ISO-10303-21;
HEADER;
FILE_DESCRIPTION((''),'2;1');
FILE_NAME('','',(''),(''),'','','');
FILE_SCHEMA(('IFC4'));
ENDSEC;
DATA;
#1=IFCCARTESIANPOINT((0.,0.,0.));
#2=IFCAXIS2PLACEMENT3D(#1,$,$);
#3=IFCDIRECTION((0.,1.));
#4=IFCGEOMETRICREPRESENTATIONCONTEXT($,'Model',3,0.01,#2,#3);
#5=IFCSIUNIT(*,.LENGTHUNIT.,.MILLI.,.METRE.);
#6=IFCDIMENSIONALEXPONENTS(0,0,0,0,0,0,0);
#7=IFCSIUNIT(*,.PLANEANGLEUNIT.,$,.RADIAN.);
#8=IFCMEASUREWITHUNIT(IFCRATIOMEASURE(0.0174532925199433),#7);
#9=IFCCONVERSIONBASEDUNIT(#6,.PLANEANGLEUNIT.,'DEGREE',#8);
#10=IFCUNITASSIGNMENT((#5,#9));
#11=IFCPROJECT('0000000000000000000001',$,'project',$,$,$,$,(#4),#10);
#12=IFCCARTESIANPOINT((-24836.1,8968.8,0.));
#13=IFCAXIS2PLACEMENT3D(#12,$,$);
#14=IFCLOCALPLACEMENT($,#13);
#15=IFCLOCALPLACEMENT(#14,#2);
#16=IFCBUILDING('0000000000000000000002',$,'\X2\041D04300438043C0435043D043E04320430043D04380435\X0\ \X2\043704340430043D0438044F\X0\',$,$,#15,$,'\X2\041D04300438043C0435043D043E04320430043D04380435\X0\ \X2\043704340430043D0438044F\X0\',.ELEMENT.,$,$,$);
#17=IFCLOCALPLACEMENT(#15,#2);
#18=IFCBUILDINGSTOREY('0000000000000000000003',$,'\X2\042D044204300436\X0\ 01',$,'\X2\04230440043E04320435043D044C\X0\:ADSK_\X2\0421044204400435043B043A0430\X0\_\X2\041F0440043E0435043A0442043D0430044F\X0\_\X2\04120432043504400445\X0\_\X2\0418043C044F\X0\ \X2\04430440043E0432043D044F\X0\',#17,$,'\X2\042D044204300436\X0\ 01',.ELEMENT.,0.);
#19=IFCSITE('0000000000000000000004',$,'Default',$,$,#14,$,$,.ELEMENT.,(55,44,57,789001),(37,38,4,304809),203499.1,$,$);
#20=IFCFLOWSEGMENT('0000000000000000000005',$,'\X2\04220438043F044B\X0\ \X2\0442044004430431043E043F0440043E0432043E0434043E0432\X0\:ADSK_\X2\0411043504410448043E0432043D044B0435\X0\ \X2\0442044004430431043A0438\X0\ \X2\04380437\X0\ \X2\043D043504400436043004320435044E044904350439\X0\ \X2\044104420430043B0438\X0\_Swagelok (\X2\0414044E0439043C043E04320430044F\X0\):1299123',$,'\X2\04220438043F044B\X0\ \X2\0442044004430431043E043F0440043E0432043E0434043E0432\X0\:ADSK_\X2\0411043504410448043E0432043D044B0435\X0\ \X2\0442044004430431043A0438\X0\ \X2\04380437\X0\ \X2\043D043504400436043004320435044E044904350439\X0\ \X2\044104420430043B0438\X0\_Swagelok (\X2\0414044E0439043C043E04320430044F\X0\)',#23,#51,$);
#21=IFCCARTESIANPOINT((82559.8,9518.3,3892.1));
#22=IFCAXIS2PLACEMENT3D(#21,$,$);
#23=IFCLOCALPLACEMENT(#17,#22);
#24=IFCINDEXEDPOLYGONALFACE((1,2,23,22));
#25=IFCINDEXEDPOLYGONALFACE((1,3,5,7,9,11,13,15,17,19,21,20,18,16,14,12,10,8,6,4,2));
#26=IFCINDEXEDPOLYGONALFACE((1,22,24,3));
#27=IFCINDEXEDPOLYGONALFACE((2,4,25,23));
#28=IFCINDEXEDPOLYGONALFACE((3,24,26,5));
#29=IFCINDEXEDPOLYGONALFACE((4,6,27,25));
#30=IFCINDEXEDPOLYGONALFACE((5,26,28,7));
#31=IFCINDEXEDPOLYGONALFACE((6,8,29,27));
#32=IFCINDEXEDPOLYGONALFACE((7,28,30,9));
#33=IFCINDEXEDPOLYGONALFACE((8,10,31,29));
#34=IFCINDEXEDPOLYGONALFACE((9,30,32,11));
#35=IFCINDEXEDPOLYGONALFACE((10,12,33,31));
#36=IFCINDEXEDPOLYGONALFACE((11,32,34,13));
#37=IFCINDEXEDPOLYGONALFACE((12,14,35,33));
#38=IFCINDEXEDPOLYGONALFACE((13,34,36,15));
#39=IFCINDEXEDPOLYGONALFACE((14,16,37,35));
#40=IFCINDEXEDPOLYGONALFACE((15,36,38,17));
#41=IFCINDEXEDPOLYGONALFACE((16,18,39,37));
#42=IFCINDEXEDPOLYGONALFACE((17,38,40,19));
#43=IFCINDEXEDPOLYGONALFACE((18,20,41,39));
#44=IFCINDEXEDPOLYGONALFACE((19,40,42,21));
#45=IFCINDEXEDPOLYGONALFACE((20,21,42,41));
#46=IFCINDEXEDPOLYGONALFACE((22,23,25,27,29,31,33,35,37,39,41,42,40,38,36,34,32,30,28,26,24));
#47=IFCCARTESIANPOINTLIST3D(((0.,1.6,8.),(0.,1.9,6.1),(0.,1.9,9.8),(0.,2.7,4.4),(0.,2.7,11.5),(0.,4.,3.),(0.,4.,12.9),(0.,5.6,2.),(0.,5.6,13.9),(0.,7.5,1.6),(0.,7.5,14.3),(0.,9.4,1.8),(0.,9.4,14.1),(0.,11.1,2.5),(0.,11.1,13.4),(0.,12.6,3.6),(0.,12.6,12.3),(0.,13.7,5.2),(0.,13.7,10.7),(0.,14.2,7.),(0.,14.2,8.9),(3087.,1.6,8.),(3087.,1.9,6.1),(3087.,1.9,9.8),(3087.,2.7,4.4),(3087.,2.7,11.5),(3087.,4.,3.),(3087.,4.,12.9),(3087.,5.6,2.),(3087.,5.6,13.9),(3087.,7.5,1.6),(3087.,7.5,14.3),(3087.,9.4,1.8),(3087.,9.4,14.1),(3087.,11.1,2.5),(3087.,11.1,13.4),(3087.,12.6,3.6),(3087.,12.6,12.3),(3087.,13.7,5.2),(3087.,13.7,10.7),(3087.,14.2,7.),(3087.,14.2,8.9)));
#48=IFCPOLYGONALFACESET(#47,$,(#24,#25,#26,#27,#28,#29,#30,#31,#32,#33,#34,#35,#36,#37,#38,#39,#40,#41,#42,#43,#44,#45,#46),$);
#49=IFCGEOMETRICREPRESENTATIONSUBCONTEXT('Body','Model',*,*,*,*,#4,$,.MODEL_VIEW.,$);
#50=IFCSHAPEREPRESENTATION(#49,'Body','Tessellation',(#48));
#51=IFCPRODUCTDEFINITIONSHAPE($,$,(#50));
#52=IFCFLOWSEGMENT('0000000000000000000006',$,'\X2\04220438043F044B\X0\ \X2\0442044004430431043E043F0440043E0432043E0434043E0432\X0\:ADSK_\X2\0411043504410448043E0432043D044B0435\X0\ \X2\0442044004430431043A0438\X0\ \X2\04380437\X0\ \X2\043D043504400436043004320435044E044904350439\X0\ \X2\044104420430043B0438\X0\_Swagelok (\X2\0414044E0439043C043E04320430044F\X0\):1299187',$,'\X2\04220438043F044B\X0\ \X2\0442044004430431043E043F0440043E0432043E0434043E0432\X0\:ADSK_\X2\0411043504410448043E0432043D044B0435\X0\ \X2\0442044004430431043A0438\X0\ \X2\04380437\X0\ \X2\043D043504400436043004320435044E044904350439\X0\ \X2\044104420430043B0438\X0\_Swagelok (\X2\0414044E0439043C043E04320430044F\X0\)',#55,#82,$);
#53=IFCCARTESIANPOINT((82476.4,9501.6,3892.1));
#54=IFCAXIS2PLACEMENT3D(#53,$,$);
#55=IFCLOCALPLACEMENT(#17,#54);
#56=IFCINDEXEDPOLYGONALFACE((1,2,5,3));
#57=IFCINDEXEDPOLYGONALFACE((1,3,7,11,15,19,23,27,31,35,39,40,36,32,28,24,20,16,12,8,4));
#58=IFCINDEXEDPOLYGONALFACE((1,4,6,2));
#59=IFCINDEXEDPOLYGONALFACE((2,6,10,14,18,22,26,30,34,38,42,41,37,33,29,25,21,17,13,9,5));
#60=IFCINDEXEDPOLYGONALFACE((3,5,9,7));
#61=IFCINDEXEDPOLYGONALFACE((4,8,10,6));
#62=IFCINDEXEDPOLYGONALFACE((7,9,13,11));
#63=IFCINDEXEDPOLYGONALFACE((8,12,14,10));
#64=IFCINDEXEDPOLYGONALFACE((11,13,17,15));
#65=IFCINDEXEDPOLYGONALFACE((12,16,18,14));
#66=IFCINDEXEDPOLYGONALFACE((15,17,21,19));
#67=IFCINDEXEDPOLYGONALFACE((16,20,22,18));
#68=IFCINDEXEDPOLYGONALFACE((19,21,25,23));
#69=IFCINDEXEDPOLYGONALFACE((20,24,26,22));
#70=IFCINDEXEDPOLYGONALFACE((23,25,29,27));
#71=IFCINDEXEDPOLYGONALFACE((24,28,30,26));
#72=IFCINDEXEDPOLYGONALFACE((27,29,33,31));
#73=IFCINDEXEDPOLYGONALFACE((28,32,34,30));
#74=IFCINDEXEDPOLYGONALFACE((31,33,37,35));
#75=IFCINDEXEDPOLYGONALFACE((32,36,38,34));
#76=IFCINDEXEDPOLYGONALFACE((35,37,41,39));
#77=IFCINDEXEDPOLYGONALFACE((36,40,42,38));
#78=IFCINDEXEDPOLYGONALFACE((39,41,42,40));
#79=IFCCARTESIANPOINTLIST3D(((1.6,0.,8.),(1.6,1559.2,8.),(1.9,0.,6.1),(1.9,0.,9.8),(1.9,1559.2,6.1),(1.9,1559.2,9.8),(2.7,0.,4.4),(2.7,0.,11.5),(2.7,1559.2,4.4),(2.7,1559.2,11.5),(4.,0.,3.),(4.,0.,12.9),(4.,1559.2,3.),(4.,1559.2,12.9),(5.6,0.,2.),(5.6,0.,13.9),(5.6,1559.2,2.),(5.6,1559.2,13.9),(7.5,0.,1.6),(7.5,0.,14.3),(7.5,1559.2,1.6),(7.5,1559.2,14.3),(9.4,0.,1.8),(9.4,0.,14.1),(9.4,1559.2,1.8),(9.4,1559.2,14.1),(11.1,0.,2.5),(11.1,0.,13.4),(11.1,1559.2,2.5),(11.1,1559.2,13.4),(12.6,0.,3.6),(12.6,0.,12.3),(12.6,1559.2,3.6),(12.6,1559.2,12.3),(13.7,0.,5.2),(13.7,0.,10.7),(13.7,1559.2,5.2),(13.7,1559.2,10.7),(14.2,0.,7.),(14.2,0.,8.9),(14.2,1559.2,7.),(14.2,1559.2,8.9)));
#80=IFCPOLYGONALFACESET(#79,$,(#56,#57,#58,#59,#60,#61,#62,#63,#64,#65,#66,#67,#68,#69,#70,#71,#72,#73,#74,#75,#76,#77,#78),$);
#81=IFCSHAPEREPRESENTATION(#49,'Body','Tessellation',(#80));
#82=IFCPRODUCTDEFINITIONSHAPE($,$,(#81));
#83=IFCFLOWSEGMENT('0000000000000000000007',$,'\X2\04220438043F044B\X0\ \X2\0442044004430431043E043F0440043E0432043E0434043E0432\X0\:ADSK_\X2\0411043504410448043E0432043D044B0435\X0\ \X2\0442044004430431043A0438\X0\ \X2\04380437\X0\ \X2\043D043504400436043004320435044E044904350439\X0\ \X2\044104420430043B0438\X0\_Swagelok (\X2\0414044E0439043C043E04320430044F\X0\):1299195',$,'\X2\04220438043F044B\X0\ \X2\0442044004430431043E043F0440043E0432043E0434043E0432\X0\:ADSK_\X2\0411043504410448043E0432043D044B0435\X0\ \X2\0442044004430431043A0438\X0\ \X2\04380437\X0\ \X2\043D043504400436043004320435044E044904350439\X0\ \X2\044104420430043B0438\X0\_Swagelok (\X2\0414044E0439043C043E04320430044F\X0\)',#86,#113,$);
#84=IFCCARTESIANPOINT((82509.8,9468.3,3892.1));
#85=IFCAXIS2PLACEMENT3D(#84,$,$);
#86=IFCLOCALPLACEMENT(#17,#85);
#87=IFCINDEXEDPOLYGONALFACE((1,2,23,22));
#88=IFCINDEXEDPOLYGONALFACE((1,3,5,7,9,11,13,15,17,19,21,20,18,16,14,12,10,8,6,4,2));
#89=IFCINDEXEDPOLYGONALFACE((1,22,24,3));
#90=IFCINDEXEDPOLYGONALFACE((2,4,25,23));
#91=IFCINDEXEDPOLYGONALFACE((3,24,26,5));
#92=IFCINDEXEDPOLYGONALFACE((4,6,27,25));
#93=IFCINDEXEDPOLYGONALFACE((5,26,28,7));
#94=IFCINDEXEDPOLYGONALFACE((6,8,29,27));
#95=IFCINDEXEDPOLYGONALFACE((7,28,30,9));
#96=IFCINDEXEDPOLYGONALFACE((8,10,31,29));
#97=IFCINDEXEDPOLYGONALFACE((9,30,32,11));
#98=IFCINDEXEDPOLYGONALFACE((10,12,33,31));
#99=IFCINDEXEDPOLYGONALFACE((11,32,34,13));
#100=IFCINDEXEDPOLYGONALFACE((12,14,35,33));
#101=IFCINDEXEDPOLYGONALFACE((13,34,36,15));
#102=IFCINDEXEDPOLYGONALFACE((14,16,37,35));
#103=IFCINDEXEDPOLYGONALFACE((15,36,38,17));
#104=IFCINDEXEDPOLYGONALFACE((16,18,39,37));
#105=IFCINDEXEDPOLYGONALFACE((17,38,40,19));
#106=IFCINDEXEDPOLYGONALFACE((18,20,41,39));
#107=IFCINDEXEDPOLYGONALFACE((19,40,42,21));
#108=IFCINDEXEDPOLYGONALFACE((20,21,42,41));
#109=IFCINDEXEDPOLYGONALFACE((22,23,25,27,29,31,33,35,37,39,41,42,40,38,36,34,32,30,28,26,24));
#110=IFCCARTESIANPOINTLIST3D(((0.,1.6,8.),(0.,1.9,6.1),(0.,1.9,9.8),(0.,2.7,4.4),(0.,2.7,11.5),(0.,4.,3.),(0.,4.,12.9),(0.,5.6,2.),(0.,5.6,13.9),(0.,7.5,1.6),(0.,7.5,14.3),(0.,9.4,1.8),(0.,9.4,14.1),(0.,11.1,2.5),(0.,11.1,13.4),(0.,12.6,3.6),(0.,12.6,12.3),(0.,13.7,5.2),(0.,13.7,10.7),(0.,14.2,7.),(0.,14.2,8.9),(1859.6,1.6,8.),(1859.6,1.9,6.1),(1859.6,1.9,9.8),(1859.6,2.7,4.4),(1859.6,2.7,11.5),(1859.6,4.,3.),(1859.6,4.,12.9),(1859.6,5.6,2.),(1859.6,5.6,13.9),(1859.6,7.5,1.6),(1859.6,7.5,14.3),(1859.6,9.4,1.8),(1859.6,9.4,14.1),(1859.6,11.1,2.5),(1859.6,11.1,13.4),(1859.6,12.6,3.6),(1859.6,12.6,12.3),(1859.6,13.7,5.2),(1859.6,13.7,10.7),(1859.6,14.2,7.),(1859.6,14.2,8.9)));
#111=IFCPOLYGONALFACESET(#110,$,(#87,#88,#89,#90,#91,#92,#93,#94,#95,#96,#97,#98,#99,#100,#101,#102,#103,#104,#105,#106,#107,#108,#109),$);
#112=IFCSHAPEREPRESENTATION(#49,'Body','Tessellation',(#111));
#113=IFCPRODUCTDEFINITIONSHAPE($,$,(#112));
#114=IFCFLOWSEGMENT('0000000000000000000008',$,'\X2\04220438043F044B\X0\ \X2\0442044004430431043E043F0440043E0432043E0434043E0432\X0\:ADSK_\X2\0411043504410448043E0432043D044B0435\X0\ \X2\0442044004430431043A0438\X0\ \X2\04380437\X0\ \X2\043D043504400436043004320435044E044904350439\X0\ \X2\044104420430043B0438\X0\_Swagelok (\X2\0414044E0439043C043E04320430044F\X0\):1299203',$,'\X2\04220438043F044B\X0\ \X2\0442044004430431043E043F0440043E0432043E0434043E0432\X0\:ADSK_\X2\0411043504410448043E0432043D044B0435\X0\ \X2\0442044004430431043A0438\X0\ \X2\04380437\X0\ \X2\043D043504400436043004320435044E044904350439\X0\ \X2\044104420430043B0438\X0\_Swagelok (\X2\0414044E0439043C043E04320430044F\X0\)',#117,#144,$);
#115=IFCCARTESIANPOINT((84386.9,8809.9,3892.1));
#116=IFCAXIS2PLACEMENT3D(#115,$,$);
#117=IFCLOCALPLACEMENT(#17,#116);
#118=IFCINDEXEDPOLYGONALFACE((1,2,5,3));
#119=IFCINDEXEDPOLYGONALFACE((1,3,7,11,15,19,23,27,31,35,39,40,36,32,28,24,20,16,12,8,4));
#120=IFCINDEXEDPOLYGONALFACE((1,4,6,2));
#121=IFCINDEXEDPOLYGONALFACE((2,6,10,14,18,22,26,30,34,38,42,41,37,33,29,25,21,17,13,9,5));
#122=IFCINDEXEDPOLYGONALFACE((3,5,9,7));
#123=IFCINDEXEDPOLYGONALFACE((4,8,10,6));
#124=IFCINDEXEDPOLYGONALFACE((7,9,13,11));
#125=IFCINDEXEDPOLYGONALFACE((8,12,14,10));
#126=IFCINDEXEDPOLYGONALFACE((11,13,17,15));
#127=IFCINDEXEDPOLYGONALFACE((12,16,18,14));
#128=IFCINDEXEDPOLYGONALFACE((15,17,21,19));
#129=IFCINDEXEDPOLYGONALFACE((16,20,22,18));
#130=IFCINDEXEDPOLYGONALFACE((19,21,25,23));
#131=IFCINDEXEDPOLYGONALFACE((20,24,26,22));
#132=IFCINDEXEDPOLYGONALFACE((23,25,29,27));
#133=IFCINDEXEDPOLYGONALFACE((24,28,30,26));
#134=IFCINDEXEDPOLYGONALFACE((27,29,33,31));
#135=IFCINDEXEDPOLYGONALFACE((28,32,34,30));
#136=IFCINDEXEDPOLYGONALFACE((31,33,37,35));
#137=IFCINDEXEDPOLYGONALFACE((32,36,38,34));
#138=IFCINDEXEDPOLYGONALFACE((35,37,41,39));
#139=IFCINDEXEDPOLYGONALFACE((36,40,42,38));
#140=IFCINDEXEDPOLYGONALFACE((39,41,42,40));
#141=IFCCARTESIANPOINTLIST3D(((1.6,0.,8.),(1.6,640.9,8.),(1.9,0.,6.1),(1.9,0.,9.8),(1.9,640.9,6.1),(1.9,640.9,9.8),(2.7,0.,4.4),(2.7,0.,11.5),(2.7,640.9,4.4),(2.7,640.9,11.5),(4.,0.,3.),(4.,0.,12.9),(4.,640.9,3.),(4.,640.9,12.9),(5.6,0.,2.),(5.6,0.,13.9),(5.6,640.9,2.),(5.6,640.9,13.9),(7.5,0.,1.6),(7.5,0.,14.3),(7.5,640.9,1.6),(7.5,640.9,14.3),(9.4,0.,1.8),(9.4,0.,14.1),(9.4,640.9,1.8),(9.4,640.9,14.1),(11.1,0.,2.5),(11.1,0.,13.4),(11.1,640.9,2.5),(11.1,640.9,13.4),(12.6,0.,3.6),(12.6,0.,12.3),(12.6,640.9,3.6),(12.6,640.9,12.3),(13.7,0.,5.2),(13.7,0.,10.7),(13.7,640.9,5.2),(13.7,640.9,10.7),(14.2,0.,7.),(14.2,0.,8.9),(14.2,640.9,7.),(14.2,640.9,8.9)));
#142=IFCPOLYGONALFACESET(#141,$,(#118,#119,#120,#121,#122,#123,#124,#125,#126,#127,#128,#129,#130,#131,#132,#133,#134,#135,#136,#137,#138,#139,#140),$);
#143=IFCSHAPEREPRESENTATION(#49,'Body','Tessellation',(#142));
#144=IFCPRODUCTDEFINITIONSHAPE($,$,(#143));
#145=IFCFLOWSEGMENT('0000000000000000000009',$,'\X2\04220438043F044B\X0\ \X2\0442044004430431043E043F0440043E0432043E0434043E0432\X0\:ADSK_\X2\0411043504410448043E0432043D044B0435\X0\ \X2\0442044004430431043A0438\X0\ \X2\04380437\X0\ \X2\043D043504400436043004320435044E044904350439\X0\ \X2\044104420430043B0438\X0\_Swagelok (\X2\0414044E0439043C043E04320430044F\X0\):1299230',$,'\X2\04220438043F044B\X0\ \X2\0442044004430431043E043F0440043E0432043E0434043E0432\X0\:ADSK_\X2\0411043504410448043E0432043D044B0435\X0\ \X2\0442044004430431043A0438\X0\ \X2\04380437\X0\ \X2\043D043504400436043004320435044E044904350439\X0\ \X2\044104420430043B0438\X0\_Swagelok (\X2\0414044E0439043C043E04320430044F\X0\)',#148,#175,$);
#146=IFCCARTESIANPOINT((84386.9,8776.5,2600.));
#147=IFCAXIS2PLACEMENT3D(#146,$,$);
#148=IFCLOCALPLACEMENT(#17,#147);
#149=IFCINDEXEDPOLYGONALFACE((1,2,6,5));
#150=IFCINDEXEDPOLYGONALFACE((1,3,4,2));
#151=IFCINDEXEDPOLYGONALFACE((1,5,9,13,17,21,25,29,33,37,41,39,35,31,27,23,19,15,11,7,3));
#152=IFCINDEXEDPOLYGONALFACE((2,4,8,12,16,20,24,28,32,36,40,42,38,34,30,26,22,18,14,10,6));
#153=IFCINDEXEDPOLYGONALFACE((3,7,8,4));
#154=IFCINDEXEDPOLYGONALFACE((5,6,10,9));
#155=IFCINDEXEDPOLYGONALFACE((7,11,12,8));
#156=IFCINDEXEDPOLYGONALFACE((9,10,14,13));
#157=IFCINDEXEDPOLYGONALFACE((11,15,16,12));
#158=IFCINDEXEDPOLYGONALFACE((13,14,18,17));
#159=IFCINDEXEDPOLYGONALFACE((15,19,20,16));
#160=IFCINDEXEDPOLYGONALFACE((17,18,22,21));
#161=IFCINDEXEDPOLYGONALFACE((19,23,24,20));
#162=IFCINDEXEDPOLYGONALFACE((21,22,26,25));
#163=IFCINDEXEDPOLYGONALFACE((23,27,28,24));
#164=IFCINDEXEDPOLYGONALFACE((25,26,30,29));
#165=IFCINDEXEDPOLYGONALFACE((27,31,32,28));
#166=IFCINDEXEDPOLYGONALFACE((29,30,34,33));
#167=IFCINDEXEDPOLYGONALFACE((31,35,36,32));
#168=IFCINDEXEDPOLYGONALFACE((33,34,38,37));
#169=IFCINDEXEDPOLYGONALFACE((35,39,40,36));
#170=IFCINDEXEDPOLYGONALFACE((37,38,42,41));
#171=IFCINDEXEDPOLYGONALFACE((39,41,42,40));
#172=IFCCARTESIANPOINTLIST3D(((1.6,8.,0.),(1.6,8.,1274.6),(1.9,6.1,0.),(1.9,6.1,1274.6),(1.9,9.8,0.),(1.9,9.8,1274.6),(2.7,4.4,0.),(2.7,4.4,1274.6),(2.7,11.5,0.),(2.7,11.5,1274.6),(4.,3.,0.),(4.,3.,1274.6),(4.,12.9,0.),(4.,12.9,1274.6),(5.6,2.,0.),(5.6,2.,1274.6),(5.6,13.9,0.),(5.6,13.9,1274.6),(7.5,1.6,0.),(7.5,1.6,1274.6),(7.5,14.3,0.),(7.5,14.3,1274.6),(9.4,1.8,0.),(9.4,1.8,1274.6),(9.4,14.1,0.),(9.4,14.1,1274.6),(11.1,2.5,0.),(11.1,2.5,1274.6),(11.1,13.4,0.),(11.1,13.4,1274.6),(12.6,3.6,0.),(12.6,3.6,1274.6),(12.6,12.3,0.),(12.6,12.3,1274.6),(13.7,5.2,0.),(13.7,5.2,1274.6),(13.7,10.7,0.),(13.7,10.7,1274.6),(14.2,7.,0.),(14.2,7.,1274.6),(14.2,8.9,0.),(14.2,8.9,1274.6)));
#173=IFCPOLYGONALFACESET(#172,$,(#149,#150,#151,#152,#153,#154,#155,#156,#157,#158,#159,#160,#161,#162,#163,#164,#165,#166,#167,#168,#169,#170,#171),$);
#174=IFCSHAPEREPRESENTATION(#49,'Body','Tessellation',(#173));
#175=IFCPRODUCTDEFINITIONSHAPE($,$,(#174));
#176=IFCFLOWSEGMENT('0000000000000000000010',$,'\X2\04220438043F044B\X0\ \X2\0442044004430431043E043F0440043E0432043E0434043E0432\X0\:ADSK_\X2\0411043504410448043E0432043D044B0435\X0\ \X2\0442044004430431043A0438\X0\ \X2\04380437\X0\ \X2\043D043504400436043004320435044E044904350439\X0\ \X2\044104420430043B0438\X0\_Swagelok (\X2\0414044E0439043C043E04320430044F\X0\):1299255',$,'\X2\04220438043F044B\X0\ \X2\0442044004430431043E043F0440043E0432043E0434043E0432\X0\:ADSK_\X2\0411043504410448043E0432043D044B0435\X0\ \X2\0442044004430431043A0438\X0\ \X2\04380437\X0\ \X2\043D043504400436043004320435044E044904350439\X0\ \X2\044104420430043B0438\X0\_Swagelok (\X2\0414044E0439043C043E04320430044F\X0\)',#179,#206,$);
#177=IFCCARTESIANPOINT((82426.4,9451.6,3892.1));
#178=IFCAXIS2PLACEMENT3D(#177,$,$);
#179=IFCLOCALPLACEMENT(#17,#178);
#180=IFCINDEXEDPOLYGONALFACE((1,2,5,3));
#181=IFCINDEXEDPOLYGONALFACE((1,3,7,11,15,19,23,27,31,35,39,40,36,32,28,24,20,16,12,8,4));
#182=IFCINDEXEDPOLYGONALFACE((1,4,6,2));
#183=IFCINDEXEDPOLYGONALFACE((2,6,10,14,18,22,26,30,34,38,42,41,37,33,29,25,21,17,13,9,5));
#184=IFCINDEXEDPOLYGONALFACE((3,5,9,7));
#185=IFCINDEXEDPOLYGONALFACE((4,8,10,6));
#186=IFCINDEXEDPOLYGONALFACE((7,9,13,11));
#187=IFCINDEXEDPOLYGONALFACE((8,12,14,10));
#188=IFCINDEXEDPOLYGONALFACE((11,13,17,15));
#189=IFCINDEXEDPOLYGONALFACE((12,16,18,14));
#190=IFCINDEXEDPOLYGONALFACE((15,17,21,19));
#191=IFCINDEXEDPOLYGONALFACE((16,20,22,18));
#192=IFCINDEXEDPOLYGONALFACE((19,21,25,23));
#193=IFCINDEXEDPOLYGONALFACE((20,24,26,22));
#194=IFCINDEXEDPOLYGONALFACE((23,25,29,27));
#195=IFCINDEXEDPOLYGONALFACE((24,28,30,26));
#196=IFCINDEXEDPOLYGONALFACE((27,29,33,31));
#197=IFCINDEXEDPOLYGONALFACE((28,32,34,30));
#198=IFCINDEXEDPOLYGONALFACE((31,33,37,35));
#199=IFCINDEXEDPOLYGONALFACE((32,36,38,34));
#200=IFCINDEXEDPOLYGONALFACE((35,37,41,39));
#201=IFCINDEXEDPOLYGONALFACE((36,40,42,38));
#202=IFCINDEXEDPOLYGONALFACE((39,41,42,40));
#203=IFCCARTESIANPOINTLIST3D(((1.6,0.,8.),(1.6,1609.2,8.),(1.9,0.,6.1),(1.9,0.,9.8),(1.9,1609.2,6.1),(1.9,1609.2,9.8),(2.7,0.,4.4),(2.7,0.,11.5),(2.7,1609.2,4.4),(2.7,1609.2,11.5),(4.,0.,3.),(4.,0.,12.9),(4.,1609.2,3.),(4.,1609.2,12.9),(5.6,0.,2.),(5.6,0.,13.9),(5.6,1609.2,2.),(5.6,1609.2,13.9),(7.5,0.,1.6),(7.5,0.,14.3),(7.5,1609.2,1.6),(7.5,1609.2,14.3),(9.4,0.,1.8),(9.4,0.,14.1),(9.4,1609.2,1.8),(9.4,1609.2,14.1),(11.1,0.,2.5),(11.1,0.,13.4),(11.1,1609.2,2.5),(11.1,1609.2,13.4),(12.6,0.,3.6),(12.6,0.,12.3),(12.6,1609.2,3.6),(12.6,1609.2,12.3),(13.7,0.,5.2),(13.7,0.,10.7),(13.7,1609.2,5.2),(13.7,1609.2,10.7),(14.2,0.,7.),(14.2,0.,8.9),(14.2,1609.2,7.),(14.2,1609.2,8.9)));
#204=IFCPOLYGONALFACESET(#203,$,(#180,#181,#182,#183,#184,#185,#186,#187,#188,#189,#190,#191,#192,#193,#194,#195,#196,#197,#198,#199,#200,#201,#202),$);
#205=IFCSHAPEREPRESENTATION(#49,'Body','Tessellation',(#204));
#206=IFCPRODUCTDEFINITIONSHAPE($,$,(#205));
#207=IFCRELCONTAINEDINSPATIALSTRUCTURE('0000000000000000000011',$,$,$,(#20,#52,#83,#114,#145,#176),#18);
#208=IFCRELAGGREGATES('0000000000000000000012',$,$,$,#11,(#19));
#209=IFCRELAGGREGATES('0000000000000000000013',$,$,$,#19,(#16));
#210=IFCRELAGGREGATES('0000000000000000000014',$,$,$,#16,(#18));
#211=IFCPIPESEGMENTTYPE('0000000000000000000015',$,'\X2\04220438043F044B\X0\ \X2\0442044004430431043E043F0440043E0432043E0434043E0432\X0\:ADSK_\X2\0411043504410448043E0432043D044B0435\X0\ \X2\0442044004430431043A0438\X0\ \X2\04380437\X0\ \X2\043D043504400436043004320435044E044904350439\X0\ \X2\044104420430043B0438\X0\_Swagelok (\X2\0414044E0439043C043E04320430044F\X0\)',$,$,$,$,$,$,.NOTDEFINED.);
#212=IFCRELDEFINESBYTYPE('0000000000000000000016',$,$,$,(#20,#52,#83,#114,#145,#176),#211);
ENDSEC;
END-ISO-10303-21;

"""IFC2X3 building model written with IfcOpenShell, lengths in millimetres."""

from ifc_helpers import new_model, entity, si_unit, converted_unit, direction, frame, origin, origin_2d_with_axis, place, context, subcontext, project, spatial, circle, extrude, type_object, element, save


model = new_model("IFC2X3")

# Units and contexts
model_context = context("Model", 3, precision=0.01, world=origin(), true_north=direction((0.0, 1.0)))
body_context = subcontext(model_context, "Body", "Model", "MODEL_VIEW")
ifc_project = project(units=[si_unit("LENGTHUNIT", "METRE", prefix="MILLI"), converted_unit("PLANEANGLEUNIT", "DEGREE", entity("IfcRatioMeasure", 0.0174532925199433), si_unit("PLANEANGLEUNIT", "RADIAN"), dimensions=[0, 0, 0, 0, 0, 0, 0])], contexts=[model_context])

# Site, building, storey
site_placement = place(None, frame((-24836.1, 8968.8, 0.0)))
site = spatial("IfcSite", under=ifc_project, at=site_placement, Name="Default", CompositionType="ELEMENT", RefLatitude=(55, 44, 57, 789001), RefLongitude=(37, 38, 4, 304809), RefElevation=203499.1)
building_placement = place(site_placement, origin())
building = spatial("IfcBuilding", under=site, at=building_placement, Name="Наименование здания", LongName="Наименование здания", CompositionType="ELEMENT")
storey_placement = place(building_placement, origin())
storey = spatial("IfcBuildingStorey", under=building, at=storey_placement, Name="Этаж 01", ObjectType="Уровень:ADSK_Стрелка_Проектная_Вверх_Имя уровня", LongName="Этаж 01", CompositionType="ELEMENT", Elevation=0.0)

# Flow segments
pipe_segment_type = type_object("IfcPipeSegmentType", Name="Типы трубопроводов:ADSK_Бесшовные трубки из нержавеющей стали_Swagelok (Дюймовая)", PredefinedType="NOTDEFINED")
flow_segment_1_placement = place(storey_placement, frame((82559.8, 9518.3, 3892.1)))
element("IfcFlowSegment", 1, at=flow_segment_1_placement, inside=storey, type_object=pipe_segment_type, Name="Типы трубопроводов:ADSK_Бесшовные трубки из нержавеющей стали_Swagelok (Дюймовая):1299123", ObjectType="Типы трубопроводов:ADSK_Бесшовные трубки из нержавеющей стали_Swagelok (Дюймовая)", context=body_context, shape_type="SweptSolid", body=[
    extrude(circle(Radius=6.3, at=origin_2d_with_axis()), frame((0.0, 8.0, 8.0), z_axis=(1.0, 0.0, 0.0), x_axis=(0.0, -1.0, 0.0)), (0.0, 0.0, 1.0), 3087.0),
])
flow_segment_2_placement = place(storey_placement, frame((82476.4, 9501.6, 3892.1)))
element("IfcFlowSegment", 2, at=flow_segment_2_placement, inside=storey, type_object=pipe_segment_type, Name="Типы трубопроводов:ADSK_Бесшовные трубки из нержавеющей стали_Swagelok (Дюймовая):1299187", ObjectType="Типы трубопроводов:ADSK_Бесшовные трубки из нержавеющей стали_Swagelok (Дюймовая)", context=body_context, shape_type="SweptSolid", body=[
    extrude(circle(Radius=6.3, at=origin_2d_with_axis()), frame((8.0, 0.0, 8.0), z_axis=(0.0, 1.0, 0.0), x_axis=(-1.0, 0.0, 0.0)), (0.0, 0.0, 1.0), 1559.2),
])
flow_segment_3_placement = place(storey_placement, frame((82509.8, 9468.3, 3892.1)))
element("IfcFlowSegment", 3, at=flow_segment_3_placement, inside=storey, type_object=pipe_segment_type, Name="Типы трубопроводов:ADSK_Бесшовные трубки из нержавеющей стали_Swagelok (Дюймовая):1299195", ObjectType="Типы трубопроводов:ADSK_Бесшовные трубки из нержавеющей стали_Swagelok (Дюймовая)", context=body_context, shape_type="SweptSolid", body=[
    extrude(circle(Radius=6.3, at=origin_2d_with_axis()), frame((0.0, 8.0, 8.0), z_axis=(1.0, 0.0, 0.0), x_axis=(0.0, -1.0, 0.0)), (0.0, 0.0, 1.0), 1859.6),
])
flow_segment_4_placement = place(storey_placement, frame((84386.9, 8809.9, 3892.1)))
element("IfcFlowSegment", 4, at=flow_segment_4_placement, inside=storey, type_object=pipe_segment_type, Name="Типы трубопроводов:ADSK_Бесшовные трубки из нержавеющей стали_Swagelok (Дюймовая):1299203", ObjectType="Типы трубопроводов:ADSK_Бесшовные трубки из нержавеющей стали_Swagelok (Дюймовая)", context=body_context, shape_type="SweptSolid", body=[
    extrude(circle(Radius=6.3, at=origin_2d_with_axis()), frame((8.0, 0.0, 8.0), z_axis=(0.0, 1.0, 0.0), x_axis=(-1.0, 0.0, 0.0)), (0.0, 0.0, 1.0), 640.9),
])
flow_segment_5_placement = place(storey_placement, frame((84386.9, 8776.5, 2600.0)))
element("IfcFlowSegment", 5, at=flow_segment_5_placement, inside=storey, type_object=pipe_segment_type, Name="Типы трубопроводов:ADSK_Бесшовные трубки из нержавеющей стали_Swagelok (Дюймовая):1299230", ObjectType="Типы трубопроводов:ADSK_Бесшовные трубки из нержавеющей стали_Swagelok (Дюймовая)", context=body_context, shape_type="SweptSolid", body=[
    extrude(circle(Radius=6.3, at=origin_2d_with_axis()), frame((8.0, 8.0, 0.0), z_axis=(0.0, 0.0, 1.0), x_axis=(-1.0, 0.0, 0.0)), (0.0, 0.0, 1.0), 1274.6),
])
flow_segment_6_placement = place(storey_placement, frame((82426.4, 9451.6, 3892.1)))
element("IfcFlowSegment", 6, at=flow_segment_6_placement, inside=storey, type_object=pipe_segment_type, Name="Типы трубопроводов:ADSK_Бесшовные трубки из нержавеющей стали_Swagelok (Дюймовая):1299255", ObjectType="Типы трубопроводов:ADSK_Бесшовные трубки из нержавеющей стали_Swagelok (Дюймовая)", context=body_context, shape_type="SweptSolid", body=[
    extrude(circle(Radius=6.3, at=origin_2d_with_axis()), frame((8.0, 0.0, 8.0), z_axis=(0.0, 1.0, 0.0), x_axis=(-1.0, 0.0, 0.0)), (0.0, 0.0, 1.0), 1609.2),
])

save(model, "model.ifc")
